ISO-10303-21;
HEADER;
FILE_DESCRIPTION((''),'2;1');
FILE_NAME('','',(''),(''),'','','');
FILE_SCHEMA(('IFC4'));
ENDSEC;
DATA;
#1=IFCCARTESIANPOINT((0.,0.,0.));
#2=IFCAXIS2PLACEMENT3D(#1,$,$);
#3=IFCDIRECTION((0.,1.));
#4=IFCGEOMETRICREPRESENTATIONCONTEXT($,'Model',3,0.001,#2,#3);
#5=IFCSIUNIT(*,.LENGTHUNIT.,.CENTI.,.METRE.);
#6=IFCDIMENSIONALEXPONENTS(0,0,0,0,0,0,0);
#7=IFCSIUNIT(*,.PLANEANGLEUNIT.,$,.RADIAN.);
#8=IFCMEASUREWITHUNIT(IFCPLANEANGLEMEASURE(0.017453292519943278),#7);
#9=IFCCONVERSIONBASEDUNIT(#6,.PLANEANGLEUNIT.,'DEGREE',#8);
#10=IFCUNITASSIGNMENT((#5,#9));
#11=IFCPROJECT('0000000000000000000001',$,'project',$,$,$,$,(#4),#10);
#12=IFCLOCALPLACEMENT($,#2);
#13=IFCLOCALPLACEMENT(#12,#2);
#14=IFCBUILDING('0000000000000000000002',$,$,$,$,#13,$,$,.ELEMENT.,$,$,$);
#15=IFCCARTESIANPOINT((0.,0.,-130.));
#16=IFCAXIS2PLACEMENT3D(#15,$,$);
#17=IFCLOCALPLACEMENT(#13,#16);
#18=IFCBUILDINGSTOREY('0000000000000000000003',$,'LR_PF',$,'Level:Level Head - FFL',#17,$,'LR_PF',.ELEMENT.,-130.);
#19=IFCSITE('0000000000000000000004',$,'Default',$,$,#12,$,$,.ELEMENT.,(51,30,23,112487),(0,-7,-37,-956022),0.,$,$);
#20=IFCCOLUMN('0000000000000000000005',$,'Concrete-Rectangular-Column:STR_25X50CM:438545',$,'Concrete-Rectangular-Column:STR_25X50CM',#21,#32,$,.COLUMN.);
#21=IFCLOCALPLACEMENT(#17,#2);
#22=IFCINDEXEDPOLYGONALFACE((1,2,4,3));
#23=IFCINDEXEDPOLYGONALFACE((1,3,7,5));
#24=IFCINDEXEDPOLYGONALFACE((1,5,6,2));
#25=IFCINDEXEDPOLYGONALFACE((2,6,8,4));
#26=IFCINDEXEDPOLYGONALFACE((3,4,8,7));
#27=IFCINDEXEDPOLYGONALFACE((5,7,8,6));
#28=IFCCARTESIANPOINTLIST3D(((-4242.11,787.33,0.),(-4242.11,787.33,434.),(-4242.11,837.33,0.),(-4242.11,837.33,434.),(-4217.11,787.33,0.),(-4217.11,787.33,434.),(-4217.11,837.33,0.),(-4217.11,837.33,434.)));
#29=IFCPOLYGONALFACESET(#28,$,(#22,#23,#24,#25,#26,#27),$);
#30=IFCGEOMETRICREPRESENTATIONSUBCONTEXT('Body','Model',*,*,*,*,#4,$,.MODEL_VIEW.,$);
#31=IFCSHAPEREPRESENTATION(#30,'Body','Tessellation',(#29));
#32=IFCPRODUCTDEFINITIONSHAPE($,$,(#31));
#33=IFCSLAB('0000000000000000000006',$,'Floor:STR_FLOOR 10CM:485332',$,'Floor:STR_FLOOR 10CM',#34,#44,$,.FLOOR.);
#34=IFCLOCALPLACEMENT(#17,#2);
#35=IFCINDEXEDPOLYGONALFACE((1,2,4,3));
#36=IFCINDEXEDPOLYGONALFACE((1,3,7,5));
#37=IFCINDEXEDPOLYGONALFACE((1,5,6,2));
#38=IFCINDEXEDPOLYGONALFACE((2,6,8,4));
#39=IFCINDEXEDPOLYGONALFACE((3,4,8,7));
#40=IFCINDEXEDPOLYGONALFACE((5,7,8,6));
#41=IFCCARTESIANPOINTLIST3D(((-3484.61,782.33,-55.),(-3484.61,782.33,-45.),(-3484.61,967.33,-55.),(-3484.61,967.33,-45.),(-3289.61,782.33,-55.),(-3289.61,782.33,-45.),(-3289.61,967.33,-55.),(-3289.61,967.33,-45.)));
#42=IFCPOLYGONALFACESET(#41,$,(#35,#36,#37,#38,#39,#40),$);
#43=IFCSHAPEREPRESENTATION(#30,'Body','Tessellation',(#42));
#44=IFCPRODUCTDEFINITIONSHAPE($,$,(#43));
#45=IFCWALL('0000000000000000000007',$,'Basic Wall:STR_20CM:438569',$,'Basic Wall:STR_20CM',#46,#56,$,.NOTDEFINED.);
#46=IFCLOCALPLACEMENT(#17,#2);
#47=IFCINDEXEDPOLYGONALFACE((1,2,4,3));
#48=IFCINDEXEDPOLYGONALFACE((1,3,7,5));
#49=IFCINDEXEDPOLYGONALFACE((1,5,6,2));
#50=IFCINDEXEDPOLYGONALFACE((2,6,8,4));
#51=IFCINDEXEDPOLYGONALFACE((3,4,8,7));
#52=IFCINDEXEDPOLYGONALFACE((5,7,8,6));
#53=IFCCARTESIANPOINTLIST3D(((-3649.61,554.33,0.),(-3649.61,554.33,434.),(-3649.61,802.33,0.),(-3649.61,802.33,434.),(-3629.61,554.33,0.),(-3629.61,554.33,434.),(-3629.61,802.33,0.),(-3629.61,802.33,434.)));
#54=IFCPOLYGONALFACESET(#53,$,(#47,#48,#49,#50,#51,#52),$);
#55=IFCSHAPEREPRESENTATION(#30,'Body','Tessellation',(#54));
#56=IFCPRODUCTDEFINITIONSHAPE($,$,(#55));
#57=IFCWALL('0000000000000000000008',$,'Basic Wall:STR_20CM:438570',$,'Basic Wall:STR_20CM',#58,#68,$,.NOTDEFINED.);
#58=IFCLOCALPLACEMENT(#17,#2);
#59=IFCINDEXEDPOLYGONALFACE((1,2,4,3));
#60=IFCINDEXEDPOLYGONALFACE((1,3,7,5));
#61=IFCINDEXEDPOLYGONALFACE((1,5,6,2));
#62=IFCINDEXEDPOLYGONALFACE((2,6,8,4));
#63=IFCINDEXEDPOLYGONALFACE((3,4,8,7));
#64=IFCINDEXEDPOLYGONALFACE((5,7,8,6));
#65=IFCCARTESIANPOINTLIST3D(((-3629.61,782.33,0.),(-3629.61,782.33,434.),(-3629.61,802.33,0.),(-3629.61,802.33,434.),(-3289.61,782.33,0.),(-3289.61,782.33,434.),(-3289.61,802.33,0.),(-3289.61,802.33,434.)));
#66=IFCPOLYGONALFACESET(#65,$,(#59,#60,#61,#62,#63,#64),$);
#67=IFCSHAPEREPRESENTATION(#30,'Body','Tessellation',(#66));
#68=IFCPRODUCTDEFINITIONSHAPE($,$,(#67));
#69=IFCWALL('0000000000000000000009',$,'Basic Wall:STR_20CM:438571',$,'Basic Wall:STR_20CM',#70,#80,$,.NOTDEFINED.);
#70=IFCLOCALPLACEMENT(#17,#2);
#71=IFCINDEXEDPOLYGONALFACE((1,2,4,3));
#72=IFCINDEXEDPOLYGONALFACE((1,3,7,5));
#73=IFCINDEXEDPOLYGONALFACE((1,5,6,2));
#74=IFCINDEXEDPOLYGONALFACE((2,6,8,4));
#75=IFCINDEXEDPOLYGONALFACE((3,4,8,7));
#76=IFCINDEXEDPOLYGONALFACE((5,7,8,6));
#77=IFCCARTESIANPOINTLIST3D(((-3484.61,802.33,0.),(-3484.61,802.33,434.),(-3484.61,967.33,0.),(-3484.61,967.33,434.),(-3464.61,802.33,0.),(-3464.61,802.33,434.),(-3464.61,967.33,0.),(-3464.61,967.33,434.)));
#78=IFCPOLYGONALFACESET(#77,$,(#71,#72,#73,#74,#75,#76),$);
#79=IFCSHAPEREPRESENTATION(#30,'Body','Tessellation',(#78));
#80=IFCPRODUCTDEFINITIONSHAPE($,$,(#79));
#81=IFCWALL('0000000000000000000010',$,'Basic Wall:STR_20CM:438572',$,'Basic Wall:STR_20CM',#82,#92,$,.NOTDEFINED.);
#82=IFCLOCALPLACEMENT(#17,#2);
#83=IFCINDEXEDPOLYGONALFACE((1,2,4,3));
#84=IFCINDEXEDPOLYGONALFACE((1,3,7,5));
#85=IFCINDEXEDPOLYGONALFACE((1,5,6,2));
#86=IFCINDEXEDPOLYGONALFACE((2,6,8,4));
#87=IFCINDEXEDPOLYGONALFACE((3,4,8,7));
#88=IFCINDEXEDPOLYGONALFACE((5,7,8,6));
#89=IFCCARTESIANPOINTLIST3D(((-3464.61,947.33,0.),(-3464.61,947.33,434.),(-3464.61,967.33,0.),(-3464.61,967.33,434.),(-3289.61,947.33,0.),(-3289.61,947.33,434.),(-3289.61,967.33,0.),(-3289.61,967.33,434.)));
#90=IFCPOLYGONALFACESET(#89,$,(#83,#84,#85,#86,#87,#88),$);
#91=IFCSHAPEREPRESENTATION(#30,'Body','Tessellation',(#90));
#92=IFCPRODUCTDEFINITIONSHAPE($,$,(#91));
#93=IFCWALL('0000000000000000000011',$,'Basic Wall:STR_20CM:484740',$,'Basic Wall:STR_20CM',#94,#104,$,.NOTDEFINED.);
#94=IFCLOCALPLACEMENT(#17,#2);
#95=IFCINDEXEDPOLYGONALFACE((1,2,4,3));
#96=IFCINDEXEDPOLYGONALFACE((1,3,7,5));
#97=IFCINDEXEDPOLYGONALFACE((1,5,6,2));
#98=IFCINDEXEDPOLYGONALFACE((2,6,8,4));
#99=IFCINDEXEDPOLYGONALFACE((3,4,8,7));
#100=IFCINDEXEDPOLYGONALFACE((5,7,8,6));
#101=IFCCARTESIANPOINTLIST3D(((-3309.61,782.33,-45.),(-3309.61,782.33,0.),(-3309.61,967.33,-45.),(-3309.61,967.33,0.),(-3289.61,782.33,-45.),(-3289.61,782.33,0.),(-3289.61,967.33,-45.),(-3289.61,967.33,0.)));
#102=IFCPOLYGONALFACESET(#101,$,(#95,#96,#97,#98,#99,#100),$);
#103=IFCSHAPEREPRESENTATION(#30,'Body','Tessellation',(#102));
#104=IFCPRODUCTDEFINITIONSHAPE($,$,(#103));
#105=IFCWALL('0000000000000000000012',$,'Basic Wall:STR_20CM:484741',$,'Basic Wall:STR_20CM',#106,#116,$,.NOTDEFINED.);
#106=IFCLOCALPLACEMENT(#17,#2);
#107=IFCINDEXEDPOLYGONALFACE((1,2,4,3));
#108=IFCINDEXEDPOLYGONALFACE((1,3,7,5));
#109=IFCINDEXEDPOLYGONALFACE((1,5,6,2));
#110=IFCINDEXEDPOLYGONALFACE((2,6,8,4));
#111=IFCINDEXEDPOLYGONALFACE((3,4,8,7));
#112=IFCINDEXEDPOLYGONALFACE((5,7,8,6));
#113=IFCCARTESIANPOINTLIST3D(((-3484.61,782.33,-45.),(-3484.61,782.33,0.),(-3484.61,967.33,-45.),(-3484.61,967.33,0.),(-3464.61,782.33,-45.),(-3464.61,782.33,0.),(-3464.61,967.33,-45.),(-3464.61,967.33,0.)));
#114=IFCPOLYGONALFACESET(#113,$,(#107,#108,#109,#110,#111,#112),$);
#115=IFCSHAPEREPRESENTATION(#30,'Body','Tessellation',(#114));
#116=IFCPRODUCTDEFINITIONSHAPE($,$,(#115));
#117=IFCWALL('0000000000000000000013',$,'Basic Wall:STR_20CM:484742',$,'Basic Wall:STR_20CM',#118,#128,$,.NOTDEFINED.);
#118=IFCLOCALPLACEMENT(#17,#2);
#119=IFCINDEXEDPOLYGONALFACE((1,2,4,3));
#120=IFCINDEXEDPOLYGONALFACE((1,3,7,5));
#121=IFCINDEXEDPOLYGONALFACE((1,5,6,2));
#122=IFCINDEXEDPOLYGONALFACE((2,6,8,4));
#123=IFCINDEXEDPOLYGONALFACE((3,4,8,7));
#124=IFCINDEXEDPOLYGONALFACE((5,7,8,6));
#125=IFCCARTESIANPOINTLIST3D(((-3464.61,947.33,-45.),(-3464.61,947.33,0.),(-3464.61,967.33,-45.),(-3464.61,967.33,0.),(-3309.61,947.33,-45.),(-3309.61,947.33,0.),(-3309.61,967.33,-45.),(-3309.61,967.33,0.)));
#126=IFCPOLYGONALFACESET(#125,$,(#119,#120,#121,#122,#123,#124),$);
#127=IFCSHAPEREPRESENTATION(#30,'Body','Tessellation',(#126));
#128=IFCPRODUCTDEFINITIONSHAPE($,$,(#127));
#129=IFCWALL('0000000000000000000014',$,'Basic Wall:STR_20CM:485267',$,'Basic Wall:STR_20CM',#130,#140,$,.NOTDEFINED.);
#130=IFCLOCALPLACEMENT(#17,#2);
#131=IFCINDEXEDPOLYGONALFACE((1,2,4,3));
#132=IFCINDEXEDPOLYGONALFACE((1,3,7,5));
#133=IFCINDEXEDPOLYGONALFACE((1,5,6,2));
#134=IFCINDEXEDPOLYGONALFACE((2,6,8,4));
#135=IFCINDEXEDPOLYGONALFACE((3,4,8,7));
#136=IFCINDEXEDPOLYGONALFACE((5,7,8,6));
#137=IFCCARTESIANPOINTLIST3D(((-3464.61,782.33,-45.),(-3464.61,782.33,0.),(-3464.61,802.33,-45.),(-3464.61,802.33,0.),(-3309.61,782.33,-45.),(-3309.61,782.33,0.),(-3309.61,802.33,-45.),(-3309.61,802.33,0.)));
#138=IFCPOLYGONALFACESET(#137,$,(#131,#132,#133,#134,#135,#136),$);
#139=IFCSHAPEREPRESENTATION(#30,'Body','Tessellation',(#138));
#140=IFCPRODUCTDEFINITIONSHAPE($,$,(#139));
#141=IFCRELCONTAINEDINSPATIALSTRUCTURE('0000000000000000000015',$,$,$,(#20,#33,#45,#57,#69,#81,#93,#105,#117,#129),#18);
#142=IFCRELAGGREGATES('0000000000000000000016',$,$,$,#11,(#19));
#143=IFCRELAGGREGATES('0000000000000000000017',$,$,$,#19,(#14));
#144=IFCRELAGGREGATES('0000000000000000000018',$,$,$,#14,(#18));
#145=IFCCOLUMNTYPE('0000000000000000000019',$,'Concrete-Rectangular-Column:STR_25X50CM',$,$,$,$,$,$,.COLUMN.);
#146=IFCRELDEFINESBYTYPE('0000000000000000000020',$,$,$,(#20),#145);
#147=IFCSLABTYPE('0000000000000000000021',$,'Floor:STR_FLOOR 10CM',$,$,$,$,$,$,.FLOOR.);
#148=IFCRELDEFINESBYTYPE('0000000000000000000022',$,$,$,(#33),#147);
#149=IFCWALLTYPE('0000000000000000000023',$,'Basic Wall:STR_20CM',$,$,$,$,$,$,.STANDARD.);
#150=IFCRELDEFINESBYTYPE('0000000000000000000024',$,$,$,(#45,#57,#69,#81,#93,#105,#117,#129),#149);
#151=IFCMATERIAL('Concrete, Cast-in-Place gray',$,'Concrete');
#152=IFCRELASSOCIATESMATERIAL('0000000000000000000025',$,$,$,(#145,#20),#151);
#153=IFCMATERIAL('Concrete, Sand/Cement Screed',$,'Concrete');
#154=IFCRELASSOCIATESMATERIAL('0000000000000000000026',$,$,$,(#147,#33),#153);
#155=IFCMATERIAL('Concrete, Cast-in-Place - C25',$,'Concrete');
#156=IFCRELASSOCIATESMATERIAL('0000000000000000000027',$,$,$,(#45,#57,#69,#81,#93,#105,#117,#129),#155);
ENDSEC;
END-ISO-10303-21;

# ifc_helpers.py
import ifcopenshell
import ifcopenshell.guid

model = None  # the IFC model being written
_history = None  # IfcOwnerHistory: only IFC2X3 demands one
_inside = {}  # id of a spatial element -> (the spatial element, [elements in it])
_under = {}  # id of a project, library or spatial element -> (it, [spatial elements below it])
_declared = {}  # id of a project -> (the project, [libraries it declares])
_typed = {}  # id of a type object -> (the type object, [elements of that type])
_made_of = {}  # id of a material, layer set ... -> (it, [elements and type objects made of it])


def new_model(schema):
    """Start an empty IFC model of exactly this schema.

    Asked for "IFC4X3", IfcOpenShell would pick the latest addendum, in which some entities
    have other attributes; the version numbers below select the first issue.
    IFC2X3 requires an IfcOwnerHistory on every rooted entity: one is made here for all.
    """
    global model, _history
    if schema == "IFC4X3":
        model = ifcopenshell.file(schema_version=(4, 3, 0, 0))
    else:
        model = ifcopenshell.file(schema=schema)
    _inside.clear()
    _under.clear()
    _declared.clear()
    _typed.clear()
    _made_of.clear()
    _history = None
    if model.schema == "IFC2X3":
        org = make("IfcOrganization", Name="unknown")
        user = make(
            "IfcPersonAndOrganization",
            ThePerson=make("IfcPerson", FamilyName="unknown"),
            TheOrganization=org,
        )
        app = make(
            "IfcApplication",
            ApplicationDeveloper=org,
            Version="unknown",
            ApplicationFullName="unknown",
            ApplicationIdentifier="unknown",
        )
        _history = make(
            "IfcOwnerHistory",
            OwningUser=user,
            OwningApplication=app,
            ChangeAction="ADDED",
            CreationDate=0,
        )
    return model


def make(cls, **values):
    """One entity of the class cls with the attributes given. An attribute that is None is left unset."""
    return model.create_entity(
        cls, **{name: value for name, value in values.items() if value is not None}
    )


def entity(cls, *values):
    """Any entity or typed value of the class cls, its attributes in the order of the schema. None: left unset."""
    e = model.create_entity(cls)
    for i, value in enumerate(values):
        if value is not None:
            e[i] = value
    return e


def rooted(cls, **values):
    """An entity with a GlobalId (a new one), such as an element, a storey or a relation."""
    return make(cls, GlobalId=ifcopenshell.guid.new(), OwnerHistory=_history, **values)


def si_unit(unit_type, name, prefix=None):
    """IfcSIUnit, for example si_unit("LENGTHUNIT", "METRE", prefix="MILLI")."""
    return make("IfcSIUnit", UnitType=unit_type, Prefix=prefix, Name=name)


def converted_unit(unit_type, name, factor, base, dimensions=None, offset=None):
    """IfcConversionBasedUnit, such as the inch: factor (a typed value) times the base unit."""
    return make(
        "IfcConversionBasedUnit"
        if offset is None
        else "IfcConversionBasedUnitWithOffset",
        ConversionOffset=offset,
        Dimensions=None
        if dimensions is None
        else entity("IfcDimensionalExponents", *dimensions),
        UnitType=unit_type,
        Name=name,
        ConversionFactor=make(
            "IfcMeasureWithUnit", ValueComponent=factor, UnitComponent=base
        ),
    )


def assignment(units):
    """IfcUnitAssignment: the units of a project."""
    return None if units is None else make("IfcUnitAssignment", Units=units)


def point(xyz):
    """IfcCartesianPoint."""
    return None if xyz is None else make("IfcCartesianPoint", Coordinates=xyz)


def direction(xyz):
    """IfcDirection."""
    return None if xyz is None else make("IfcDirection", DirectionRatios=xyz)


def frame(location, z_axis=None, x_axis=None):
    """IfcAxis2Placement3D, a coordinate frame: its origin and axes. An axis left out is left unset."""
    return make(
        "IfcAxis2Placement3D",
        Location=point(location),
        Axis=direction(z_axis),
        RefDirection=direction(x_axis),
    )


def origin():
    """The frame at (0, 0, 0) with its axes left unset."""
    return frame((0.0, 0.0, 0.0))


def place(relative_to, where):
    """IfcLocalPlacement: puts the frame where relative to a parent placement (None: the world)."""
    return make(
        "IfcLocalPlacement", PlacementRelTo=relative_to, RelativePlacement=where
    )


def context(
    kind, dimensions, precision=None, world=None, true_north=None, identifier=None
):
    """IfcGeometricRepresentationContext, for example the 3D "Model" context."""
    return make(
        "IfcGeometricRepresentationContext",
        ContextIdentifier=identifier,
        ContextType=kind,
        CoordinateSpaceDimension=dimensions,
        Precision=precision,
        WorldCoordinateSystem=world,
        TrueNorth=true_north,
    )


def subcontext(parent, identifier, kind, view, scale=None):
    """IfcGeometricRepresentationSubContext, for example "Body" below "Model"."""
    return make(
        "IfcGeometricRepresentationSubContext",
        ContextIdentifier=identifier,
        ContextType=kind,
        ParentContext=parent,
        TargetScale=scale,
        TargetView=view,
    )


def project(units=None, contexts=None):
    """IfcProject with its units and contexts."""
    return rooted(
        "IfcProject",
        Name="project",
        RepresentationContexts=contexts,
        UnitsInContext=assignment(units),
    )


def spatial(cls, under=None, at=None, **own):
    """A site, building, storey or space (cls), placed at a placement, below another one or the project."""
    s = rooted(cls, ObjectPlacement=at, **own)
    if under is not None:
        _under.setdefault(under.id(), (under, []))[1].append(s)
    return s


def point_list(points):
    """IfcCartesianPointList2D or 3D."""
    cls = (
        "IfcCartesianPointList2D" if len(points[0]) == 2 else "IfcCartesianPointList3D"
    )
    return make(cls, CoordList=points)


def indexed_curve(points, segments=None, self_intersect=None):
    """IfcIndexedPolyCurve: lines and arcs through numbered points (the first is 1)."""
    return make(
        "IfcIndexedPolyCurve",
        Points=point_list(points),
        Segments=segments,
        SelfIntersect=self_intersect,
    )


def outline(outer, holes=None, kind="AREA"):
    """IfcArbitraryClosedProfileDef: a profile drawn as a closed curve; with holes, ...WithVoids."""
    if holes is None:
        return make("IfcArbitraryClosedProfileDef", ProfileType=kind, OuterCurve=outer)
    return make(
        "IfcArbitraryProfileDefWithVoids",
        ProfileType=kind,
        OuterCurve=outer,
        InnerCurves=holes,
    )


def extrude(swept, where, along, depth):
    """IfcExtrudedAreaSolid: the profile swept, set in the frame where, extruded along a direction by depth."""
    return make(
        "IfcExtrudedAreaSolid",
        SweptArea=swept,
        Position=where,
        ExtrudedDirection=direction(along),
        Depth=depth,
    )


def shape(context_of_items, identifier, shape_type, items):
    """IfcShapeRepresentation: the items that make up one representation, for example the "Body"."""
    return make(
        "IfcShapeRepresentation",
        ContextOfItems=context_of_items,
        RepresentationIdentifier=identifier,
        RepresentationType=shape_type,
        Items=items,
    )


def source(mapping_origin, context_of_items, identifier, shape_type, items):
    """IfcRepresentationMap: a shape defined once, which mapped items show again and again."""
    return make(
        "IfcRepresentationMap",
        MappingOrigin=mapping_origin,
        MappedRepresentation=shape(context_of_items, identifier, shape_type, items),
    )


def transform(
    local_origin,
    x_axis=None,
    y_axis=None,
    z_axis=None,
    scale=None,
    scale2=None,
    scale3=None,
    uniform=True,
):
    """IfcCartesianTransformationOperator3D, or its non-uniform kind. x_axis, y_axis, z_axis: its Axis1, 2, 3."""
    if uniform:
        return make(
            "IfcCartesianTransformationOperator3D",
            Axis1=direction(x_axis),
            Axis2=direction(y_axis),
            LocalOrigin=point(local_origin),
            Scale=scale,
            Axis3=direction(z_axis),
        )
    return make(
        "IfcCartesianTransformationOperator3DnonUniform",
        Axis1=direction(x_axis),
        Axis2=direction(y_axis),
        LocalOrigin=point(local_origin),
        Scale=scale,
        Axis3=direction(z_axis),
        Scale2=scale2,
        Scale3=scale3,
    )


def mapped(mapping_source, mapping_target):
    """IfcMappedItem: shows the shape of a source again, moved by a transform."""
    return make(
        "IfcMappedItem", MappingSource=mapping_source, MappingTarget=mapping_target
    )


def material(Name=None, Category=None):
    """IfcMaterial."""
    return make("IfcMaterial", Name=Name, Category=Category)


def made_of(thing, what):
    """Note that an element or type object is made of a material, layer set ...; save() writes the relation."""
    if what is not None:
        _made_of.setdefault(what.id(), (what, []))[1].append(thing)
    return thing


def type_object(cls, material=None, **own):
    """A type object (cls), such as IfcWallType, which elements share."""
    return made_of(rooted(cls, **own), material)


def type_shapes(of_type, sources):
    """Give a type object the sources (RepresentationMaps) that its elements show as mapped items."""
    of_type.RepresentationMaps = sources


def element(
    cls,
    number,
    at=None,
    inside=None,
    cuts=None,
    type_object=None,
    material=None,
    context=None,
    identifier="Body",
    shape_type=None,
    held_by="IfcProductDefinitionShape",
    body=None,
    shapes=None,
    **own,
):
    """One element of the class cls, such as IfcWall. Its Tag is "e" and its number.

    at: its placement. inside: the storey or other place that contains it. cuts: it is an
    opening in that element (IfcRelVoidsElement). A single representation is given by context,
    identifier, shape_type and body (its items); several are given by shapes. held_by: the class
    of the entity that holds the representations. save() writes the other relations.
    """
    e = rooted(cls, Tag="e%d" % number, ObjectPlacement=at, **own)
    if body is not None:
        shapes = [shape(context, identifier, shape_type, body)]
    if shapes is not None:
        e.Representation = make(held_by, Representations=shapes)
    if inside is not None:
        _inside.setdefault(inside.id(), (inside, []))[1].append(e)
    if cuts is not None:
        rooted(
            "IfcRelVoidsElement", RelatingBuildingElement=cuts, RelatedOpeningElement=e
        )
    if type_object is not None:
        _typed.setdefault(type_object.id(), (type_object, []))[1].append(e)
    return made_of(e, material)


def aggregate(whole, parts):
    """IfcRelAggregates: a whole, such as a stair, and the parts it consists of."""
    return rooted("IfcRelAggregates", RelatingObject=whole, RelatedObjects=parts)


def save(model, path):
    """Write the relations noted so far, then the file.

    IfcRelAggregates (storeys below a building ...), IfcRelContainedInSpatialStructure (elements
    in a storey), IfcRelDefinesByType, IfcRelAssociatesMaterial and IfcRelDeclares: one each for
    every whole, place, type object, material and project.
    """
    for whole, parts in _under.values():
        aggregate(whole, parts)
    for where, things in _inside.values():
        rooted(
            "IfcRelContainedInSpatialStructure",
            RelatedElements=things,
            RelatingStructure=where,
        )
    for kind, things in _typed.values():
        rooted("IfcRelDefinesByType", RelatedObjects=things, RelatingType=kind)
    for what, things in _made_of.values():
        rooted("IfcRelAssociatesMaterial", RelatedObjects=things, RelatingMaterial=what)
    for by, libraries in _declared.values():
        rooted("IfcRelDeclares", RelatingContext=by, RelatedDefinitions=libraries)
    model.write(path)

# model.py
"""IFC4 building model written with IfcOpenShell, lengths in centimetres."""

from ifc_helpers import new_model, entity, si_unit, converted_unit, direction, frame, origin, place, context, subcontext, project, spatial, indexed_curve, outline, extrude, source, transform, mapped, material, type_object, type_shapes, element, save


model = new_model("IFC4")

# Units and contexts
model_context = context("Model", 3, precision=0.001, world=origin(), true_north=direction((0.0, 1.0)))
body_context = subcontext(model_context, "Body", "Model", "MODEL_VIEW")
ifc_project = project(units=[si_unit("LENGTHUNIT", "METRE", prefix="CENTI"), converted_unit("PLANEANGLEUNIT", "DEGREE", entity("IfcPlaneAngleMeasure", 0.017453292519943278), si_unit("PLANEANGLEUNIT", "RADIAN"), dimensions=[0, 0, 0, 0, 0, 0, 0])], contexts=[model_context])

# Site, building, storey
site_placement = place(None, origin())
site = spatial("IfcSite", under=ifc_project, at=site_placement, Name="Default", CompositionType="ELEMENT", RefLatitude=(51, 30, 23, 112487), RefLongitude=(0, -7, -37, -956022), RefElevation=0.0)
building_placement = place(site_placement, origin())
building = spatial("IfcBuilding", under=site, at=building_placement, CompositionType="ELEMENT")
storey_placement = place(building_placement, frame((0.0, 0.0, -130.0)))
storey = spatial("IfcBuildingStorey", under=building, at=storey_placement, Name="LR_PF", ObjectType="Level:Level Head - FFL", LongName="LR_PF", CompositionType="ELEMENT", Elevation=-130.0)

# Column
ifc_material_1 = material(Name="Concrete, Cast-in-Place gray", Category="Concrete")
column_type = type_object("IfcColumnType", Name="Concrete-Rectangular-Column:STR_25X50CM", PredefinedType="COLUMN", material=ifc_material_1)
shared_shape = source(origin(), body_context, "Body", "SweptSolid", [
    extrude(outline(indexed_curve([(-12.5, -25.0), (12.5, -25.0), (12.5, 25.0), (-12.5, 25.0), (-12.5, -25.0)], self_intersect=False)), frame((-4229.61, 812.33, -130.0), z_axis=(0.0, 0.0, 1.0), x_axis=(-1.0, 0.0, 0.0)), (0.0, 0.0, 1.0), 434.0),
])
type_shapes(column_type, [shared_shape])
column_placement = place(storey_placement, frame((0.0, 0.0, 130.0)))
element("IfcColumn", 1, at=column_placement, inside=storey, type_object=column_type, material=ifc_material_1, Name="Concrete-Rectangular-Column:STR_25X50CM:438545", ObjectType="Concrete-Rectangular-Column:STR_25X50CM", PredefinedType="COLUMN", context=body_context, shape_type="MappedRepresentation", body=[
    mapped(shared_shape, transform((0.0, 0.0, 0.0), scale=1.0)),
])

# Shared definitions
ifc_material_2 = material(Name="Concrete, Sand/Cement Screed", Category="Concrete")
slab_type = type_object("IfcSlabType", Name="Floor:STR_FLOOR 10CM", PredefinedType="FLOOR", material=ifc_material_2)

# Slab
slab_1_placement = place(storey_placement, origin())
element("IfcSlab", 2, at=slab_1_placement, inside=storey, type_object=slab_type, material=ifc_material_2, Name="Floor:STR_FLOOR 10CM:485332", ObjectType="Floor:STR_FLOOR 10CM", PredefinedType="FLOOR", context=body_context, shape_type="SweptSolid", body=[
    extrude(outline(indexed_curve([(-92.5, -97.5), (92.5, -97.5), (92.5, 97.5), (-92.5, 97.5), (-92.5, -97.5)], self_intersect=False)), frame((-3387.11, 874.83, -45.0), z_axis=(0.0, 0.0, -1.0), x_axis=(0.0, 1.0, 0.0)), (0.0, 0.0, 1.0), 10.0),
])

# Walls
ifc_material_3 = material(Name="Concrete, Cast-in-Place - C25", Category="Concrete")
wall_type = type_object("IfcWallType", Name="Basic Wall:STR_20CM", PredefinedType="STANDARD")
wall_1_placement = place(storey_placement, frame((-3639.61, 554.33, 0.0), z_axis=(0.0, 0.0, 1.0), x_axis=(0.0, 1.0, 0.0)))
element("IfcWall", 3, at=wall_1_placement, inside=storey, type_object=wall_type, material=ifc_material_3, Name="Basic Wall:STR_20CM:438569", ObjectType="Basic Wall:STR_20CM", PredefinedType="NOTDEFINED", context=body_context, shape_type="SweptSolid", body=[
    extrude(outline(indexed_curve([(248.0, 10.0), (0.0, 10.0), (0.0, -10.0), (248.0, -10.0), (248.0, 10.0)], self_intersect=False)), origin(), (0.0, 0.0, 1.0), 434.0),
])
wall_2_placement = place(storey_placement, frame((-3289.61, 792.33, 0.0), z_axis=(0.0, 0.0, 1.0), x_axis=(-1.0, 0.0, 0.0)))
element("IfcWall", 4, at=wall_2_placement, inside=storey, type_object=wall_type, material=ifc_material_3, Name="Basic Wall:STR_20CM:438570", ObjectType="Basic Wall:STR_20CM", PredefinedType="NOTDEFINED", context=body_context, shape_type="SweptSolid", body=[
    extrude(outline(indexed_curve([(340.0, 10.0), (0.0, 10.0), (0.0, -10.0), (340.0, -10.0), (340.0, 10.0)], self_intersect=False)), origin(), (0.0, 0.0, 1.0), 434.0),
])
wall_3_placement = place(storey_placement, frame((-3474.61, 802.33, 0.0), z_axis=(0.0, 0.0, 1.0), x_axis=(0.0, 1.0, 0.0)))
element("IfcWall", 5, at=wall_3_placement, inside=storey, type_object=wall_type, material=ifc_material_3, Name="Basic Wall:STR_20CM:438571", ObjectType="Basic Wall:STR_20CM", PredefinedType="NOTDEFINED", context=body_context, shape_type="SweptSolid", body=[
    extrude(outline(indexed_curve([(165.0, 10.0), (0.0, 10.0), (0.0, -10.0), (165.0, -10.0), (165.0, 10.0)], self_intersect=False)), origin(), (0.0, 0.0, 1.0), 434.0),
])
wall_4_placement = place(storey_placement, frame((-3464.61, 957.33, 0.0)))
element("IfcWall", 6, at=wall_4_placement, inside=storey, type_object=wall_type, material=ifc_material_3, Name="Basic Wall:STR_20CM:438572", ObjectType="Basic Wall:STR_20CM", PredefinedType="NOTDEFINED", context=body_context, shape_type="SweptSolid", body=[
    extrude(outline(indexed_curve([(175.0, 10.0), (0.0, 10.0), (0.0, -10.0), (175.0, -10.0), (175.0, 10.0)], self_intersect=False)), origin(), (0.0, 0.0, 1.0), 434.0),
])
for number, where, z_axis, x_axis, name in (
    (7, (-3299.61, 782.33, -45.0), (0.0, 0.0, 1.0), (0.0, 1.0, 0.0), "Basic Wall:STR_20CM:484740"),
    (8, (-3474.61, 782.33, -45.0), (0.0, 0.0, 1.0), (0.0, 1.0, 0.0), "Basic Wall:STR_20CM:484741"),
):
    element("IfcWall", number, at=place(storey_placement, frame(where, z_axis=z_axis, x_axis=x_axis)), inside=storey, type_object=wall_type, material=ifc_material_3, Name=name, ObjectType="Basic Wall:STR_20CM", PredefinedType="NOTDEFINED", context=body_context, shape_type="SweptSolid", body=[
        extrude(outline(indexed_curve([(185.0, 10.0), (0.0, 10.0), (0.0, -10.0), (185.0, -10.0), (185.0, 10.0)], self_intersect=False)), origin(), (0.0, 0.0, 1.0), 45.0),
    ])
for number, where, z_axis, x_axis, name in (
    (9, (-3309.61, 957.33, -45.0), (0.0, 0.0, 1.0), (-1.0, 0.0, 0.0), "Basic Wall:STR_20CM:484742"),
    (10, (-3309.61, 792.33, -45.0), (0.0, 0.0, 1.0), (-1.0, 0.0, 0.0), "Basic Wall:STR_20CM:485267"),
):
    element("IfcWall", number, at=place(storey_placement, frame(where, z_axis=z_axis, x_axis=x_axis)), inside=storey, type_object=wall_type, material=ifc_material_3, Name=name, ObjectType="Basic Wall:STR_20CM", PredefinedType="NOTDEFINED", context=body_context, shape_type="SweptSolid", body=[
        extrude(outline(indexed_curve([(155.0, 10.0), (0.0, 10.0), (0.0, -10.0), (155.0, -10.0), (155.0, 10.0)], self_intersect=False)), origin(), (0.0, 0.0, 1.0), 45.0),
    ])

save(model, "model.ifc")
